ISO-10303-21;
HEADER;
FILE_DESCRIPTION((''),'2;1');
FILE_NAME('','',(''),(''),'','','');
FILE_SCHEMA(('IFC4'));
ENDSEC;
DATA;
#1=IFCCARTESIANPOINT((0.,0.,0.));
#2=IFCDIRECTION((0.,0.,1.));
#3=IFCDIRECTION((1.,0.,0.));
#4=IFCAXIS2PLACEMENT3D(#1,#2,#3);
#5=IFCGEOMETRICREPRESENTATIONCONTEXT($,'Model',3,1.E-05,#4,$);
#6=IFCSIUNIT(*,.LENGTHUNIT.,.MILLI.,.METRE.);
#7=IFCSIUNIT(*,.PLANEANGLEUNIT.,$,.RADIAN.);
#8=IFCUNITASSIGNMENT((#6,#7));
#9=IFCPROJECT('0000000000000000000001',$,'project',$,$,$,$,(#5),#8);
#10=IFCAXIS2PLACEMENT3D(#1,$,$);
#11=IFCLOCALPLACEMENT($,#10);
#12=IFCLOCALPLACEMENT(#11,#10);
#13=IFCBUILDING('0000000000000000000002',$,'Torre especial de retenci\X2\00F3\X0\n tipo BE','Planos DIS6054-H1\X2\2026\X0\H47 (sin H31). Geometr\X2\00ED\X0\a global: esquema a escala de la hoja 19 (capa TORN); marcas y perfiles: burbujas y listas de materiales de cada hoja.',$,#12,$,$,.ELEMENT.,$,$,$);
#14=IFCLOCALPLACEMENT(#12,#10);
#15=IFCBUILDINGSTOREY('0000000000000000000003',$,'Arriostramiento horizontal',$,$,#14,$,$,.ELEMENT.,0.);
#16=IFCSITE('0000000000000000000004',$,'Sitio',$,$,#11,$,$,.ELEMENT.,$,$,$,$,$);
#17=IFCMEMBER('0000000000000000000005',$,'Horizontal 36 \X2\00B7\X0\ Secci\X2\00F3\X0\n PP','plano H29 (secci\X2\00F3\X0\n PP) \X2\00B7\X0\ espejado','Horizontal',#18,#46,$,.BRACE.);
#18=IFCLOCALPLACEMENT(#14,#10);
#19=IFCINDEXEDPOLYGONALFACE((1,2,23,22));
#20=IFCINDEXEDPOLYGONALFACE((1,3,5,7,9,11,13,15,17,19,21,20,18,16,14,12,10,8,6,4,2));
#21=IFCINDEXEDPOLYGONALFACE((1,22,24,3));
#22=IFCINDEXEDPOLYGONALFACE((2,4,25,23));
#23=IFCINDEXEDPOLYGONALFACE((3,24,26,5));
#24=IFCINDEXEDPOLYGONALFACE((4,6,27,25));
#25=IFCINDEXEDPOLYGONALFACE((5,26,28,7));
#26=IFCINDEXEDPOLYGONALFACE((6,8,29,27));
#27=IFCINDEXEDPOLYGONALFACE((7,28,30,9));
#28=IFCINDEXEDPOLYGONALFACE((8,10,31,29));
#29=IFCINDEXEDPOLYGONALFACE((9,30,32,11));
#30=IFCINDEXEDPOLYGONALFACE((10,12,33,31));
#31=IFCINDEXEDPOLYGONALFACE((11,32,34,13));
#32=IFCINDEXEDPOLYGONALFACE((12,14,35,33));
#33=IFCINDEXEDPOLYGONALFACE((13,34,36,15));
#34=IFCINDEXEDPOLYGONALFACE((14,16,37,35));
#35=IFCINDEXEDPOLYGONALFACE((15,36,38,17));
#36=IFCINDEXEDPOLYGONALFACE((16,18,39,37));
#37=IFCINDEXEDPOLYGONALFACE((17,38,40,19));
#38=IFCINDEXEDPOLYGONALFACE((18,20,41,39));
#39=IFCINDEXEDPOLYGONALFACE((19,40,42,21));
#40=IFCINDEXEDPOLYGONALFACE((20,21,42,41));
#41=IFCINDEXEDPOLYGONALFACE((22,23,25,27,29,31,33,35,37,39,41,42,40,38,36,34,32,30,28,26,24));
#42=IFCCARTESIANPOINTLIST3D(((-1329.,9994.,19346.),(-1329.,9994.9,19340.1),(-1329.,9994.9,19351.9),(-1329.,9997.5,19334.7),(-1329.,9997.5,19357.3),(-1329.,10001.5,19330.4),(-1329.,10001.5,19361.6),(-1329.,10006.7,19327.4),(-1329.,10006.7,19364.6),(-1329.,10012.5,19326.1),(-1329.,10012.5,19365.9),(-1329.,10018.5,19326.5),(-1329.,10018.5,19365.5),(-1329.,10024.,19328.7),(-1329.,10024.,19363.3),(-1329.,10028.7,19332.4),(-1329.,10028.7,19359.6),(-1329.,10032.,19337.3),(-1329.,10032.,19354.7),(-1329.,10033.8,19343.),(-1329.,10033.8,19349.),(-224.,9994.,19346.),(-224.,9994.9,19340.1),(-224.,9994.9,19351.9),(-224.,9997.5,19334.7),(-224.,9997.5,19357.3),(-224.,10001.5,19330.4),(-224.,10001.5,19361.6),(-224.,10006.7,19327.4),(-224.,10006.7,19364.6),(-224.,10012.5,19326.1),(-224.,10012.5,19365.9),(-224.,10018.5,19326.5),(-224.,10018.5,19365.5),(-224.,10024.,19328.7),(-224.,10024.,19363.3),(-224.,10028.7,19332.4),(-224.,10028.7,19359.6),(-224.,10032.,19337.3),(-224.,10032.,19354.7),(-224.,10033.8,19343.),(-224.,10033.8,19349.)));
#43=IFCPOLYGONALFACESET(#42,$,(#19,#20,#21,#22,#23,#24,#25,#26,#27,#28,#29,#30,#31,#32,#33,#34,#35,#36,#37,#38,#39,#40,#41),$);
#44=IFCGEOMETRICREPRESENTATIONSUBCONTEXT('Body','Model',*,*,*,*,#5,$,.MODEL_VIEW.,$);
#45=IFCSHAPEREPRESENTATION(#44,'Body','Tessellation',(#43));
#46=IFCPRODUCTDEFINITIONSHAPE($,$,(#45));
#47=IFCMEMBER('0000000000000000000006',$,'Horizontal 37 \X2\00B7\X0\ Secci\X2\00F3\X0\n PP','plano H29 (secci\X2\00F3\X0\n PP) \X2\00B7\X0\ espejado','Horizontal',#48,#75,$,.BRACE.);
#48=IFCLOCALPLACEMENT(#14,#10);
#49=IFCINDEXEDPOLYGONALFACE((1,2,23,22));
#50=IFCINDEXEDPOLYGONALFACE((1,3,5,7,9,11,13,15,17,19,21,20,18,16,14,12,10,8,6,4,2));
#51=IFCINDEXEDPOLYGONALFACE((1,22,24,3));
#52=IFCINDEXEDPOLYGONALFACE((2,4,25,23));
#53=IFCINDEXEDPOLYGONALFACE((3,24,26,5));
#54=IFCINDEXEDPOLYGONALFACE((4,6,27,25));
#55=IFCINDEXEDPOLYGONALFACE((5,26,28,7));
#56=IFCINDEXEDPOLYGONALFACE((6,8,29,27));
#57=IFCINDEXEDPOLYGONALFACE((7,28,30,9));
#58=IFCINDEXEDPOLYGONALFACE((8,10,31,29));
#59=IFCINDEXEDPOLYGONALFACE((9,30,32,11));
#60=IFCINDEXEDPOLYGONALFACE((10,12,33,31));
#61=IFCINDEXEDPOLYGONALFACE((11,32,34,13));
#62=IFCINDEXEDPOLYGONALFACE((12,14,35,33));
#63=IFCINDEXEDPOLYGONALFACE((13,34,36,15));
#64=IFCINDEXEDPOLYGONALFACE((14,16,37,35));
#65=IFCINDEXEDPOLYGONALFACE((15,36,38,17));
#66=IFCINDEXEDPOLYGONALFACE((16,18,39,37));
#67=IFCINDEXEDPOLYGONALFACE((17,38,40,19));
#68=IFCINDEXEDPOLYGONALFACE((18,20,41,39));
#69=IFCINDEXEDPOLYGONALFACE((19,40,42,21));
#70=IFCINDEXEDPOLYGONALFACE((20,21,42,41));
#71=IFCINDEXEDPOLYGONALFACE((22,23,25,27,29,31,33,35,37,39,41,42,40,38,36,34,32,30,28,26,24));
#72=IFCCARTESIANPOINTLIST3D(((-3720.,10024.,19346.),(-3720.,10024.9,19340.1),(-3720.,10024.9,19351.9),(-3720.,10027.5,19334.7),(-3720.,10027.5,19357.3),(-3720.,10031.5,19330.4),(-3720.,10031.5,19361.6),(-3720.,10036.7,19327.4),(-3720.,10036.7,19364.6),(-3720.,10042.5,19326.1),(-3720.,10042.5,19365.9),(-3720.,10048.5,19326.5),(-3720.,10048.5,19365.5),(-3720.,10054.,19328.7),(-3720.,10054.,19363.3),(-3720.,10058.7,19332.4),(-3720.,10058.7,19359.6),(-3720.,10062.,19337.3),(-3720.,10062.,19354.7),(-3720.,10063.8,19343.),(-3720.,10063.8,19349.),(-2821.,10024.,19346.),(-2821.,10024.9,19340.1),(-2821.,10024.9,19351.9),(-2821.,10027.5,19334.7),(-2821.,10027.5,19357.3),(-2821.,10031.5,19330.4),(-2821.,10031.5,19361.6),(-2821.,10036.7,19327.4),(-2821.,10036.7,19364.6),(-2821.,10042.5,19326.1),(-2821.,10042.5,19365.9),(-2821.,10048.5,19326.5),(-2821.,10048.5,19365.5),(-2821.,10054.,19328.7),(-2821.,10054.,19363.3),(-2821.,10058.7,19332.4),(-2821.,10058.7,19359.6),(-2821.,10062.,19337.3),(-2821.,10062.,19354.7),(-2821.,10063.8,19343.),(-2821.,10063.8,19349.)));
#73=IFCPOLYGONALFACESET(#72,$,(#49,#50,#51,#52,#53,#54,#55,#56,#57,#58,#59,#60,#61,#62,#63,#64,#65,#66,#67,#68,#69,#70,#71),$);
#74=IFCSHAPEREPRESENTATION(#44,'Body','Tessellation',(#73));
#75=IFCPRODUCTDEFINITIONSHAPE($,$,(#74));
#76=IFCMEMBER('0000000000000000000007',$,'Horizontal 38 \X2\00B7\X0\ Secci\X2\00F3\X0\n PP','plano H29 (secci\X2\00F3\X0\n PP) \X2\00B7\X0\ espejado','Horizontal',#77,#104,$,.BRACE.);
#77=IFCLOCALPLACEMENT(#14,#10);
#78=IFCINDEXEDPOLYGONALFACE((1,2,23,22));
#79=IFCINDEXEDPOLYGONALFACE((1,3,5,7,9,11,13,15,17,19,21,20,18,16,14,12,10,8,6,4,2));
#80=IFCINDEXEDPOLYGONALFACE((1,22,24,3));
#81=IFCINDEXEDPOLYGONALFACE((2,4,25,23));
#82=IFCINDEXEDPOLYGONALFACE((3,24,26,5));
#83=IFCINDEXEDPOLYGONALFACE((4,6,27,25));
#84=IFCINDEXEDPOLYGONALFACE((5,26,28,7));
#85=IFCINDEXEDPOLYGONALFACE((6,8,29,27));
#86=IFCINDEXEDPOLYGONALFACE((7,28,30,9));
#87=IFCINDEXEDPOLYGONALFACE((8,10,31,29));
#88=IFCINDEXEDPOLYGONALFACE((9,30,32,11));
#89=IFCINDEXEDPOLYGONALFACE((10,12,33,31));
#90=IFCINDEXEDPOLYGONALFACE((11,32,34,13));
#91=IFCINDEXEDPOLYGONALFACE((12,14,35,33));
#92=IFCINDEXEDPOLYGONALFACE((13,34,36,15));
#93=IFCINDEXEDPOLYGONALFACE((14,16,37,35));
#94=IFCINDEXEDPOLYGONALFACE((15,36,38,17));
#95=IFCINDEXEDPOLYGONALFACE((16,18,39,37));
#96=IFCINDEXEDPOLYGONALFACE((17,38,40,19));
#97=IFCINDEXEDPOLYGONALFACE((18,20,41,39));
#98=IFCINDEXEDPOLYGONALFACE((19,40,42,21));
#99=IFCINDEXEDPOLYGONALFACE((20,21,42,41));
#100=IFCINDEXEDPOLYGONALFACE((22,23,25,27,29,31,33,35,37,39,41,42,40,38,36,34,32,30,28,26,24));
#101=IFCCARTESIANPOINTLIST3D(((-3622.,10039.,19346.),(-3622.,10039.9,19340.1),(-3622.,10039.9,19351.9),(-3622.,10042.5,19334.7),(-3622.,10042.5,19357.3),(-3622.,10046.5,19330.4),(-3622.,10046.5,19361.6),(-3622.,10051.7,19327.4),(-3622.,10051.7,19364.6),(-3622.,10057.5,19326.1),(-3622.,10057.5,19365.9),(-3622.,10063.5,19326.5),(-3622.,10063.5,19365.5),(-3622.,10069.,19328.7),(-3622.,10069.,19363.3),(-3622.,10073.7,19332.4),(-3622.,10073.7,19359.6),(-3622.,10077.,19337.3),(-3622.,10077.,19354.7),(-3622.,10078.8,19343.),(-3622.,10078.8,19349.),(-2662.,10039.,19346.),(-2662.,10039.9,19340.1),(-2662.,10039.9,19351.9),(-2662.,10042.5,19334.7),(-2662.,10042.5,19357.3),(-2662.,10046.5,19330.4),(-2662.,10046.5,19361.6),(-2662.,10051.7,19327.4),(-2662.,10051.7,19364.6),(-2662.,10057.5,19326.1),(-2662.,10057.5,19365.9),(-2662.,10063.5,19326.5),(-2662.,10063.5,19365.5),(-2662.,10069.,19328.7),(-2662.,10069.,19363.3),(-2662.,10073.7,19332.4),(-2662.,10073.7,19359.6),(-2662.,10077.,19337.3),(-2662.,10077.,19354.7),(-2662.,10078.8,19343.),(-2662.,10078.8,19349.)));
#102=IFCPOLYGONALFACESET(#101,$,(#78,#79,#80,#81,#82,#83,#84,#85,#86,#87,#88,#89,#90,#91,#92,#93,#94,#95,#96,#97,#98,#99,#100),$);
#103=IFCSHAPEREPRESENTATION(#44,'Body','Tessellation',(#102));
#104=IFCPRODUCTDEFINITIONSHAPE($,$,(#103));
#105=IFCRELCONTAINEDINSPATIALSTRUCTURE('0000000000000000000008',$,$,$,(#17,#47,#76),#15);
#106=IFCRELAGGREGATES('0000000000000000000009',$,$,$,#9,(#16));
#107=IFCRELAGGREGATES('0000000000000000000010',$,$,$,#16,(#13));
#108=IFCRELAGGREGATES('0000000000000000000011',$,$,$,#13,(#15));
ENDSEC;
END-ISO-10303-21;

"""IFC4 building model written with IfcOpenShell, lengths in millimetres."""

from ifc_helpers import new_model, si_unit, frame, origin, origin_with_axes, place, context, subcontext, project, spatial, circle, extrude, element, save


model = new_model("IFC4")

# Units and contexts
model_context = context("Model", 3, precision=1e-05, world=origin_with_axes())
body_context = subcontext(model_context, "Body", "Model", "MODEL_VIEW")
ifc_project = project(units=[si_unit("LENGTHUNIT", "METRE", prefix="MILLI"), si_unit("PLANEANGLEUNIT", "RADIAN")], contexts=[model_context])

# Site, building, storey
site_placement = place(None, origin())
site = spatial("IfcSite", under=ifc_project, at=site_placement, Name="Sitio", CompositionType="ELEMENT")
building_placement = place(site_placement, origin())
building = spatial("IfcBuilding", under=site, at=building_placement, Name="Torre especial de retención tipo BE", Description="Planos DIS6054-H1…H47 (sin H31). Geometría global: esquema a escala de la hoja 19 (capa TORN); marcas y perfiles: burbujas y listas de materiales de cada hoja.", CompositionType="ELEMENT")
storey_placement = place(building_placement, origin())
storey = spatial("IfcBuildingStorey", under=building, at=storey_placement, Name="Arriostramiento horizontal", CompositionType="ELEMENT", Elevation=0.0)

# Members
member_1_placement = place(storey_placement, frame((-1329.0, 10014.0, 19346.0), z_axis=(1.0, 0.0, 0.0), x_axis=(0.0, -1.0, 0.0)))
element("IfcMember", 1, at=member_1_placement, inside=storey, Name="Horizontal 36 · Sección PP", Description="plano H29 (sección PP) · espejado", ObjectType="Horizontal", PredefinedType="BRACE", context=body_context, shape_type="SweptSolid", body=[
    extrude(circle(Radius=20.0), None, (0.0, 0.0, 1.0), 1105.0),
])
member_2_placement = place(storey_placement, frame((-3720.0, 10044.0, 19346.0), z_axis=(1.0, 0.0, 0.0), x_axis=(0.0, -1.0, 0.0)))
element("IfcMember", 2, at=member_2_placement, inside=storey, Name="Horizontal 37 · Sección PP", Description="plano H29 (sección PP) · espejado", ObjectType="Horizontal", PredefinedType="BRACE", context=body_context, shape_type="SweptSolid", body=[
    extrude(circle(Radius=20.0), None, (0.0, 0.0, 1.0), 899.0),
])
member_3_placement = place(storey_placement, frame((-3622.0, 10059.0, 19346.0), z_axis=(1.0, 0.0, 0.0), x_axis=(0.0, -1.0, 0.0)))
element("IfcMember", 3, at=member_3_placement, inside=storey, Name="Horizontal 38 · Sección PP", Description="plano H29 (sección PP) · espejado", ObjectType="Horizontal", PredefinedType="BRACE", context=body_context, shape_type="SweptSolid", body=[
    extrude(circle(Radius=20.0), None, (0.0, 0.0, 1.0), 960.0),
])

save(model, "model.ifc")
